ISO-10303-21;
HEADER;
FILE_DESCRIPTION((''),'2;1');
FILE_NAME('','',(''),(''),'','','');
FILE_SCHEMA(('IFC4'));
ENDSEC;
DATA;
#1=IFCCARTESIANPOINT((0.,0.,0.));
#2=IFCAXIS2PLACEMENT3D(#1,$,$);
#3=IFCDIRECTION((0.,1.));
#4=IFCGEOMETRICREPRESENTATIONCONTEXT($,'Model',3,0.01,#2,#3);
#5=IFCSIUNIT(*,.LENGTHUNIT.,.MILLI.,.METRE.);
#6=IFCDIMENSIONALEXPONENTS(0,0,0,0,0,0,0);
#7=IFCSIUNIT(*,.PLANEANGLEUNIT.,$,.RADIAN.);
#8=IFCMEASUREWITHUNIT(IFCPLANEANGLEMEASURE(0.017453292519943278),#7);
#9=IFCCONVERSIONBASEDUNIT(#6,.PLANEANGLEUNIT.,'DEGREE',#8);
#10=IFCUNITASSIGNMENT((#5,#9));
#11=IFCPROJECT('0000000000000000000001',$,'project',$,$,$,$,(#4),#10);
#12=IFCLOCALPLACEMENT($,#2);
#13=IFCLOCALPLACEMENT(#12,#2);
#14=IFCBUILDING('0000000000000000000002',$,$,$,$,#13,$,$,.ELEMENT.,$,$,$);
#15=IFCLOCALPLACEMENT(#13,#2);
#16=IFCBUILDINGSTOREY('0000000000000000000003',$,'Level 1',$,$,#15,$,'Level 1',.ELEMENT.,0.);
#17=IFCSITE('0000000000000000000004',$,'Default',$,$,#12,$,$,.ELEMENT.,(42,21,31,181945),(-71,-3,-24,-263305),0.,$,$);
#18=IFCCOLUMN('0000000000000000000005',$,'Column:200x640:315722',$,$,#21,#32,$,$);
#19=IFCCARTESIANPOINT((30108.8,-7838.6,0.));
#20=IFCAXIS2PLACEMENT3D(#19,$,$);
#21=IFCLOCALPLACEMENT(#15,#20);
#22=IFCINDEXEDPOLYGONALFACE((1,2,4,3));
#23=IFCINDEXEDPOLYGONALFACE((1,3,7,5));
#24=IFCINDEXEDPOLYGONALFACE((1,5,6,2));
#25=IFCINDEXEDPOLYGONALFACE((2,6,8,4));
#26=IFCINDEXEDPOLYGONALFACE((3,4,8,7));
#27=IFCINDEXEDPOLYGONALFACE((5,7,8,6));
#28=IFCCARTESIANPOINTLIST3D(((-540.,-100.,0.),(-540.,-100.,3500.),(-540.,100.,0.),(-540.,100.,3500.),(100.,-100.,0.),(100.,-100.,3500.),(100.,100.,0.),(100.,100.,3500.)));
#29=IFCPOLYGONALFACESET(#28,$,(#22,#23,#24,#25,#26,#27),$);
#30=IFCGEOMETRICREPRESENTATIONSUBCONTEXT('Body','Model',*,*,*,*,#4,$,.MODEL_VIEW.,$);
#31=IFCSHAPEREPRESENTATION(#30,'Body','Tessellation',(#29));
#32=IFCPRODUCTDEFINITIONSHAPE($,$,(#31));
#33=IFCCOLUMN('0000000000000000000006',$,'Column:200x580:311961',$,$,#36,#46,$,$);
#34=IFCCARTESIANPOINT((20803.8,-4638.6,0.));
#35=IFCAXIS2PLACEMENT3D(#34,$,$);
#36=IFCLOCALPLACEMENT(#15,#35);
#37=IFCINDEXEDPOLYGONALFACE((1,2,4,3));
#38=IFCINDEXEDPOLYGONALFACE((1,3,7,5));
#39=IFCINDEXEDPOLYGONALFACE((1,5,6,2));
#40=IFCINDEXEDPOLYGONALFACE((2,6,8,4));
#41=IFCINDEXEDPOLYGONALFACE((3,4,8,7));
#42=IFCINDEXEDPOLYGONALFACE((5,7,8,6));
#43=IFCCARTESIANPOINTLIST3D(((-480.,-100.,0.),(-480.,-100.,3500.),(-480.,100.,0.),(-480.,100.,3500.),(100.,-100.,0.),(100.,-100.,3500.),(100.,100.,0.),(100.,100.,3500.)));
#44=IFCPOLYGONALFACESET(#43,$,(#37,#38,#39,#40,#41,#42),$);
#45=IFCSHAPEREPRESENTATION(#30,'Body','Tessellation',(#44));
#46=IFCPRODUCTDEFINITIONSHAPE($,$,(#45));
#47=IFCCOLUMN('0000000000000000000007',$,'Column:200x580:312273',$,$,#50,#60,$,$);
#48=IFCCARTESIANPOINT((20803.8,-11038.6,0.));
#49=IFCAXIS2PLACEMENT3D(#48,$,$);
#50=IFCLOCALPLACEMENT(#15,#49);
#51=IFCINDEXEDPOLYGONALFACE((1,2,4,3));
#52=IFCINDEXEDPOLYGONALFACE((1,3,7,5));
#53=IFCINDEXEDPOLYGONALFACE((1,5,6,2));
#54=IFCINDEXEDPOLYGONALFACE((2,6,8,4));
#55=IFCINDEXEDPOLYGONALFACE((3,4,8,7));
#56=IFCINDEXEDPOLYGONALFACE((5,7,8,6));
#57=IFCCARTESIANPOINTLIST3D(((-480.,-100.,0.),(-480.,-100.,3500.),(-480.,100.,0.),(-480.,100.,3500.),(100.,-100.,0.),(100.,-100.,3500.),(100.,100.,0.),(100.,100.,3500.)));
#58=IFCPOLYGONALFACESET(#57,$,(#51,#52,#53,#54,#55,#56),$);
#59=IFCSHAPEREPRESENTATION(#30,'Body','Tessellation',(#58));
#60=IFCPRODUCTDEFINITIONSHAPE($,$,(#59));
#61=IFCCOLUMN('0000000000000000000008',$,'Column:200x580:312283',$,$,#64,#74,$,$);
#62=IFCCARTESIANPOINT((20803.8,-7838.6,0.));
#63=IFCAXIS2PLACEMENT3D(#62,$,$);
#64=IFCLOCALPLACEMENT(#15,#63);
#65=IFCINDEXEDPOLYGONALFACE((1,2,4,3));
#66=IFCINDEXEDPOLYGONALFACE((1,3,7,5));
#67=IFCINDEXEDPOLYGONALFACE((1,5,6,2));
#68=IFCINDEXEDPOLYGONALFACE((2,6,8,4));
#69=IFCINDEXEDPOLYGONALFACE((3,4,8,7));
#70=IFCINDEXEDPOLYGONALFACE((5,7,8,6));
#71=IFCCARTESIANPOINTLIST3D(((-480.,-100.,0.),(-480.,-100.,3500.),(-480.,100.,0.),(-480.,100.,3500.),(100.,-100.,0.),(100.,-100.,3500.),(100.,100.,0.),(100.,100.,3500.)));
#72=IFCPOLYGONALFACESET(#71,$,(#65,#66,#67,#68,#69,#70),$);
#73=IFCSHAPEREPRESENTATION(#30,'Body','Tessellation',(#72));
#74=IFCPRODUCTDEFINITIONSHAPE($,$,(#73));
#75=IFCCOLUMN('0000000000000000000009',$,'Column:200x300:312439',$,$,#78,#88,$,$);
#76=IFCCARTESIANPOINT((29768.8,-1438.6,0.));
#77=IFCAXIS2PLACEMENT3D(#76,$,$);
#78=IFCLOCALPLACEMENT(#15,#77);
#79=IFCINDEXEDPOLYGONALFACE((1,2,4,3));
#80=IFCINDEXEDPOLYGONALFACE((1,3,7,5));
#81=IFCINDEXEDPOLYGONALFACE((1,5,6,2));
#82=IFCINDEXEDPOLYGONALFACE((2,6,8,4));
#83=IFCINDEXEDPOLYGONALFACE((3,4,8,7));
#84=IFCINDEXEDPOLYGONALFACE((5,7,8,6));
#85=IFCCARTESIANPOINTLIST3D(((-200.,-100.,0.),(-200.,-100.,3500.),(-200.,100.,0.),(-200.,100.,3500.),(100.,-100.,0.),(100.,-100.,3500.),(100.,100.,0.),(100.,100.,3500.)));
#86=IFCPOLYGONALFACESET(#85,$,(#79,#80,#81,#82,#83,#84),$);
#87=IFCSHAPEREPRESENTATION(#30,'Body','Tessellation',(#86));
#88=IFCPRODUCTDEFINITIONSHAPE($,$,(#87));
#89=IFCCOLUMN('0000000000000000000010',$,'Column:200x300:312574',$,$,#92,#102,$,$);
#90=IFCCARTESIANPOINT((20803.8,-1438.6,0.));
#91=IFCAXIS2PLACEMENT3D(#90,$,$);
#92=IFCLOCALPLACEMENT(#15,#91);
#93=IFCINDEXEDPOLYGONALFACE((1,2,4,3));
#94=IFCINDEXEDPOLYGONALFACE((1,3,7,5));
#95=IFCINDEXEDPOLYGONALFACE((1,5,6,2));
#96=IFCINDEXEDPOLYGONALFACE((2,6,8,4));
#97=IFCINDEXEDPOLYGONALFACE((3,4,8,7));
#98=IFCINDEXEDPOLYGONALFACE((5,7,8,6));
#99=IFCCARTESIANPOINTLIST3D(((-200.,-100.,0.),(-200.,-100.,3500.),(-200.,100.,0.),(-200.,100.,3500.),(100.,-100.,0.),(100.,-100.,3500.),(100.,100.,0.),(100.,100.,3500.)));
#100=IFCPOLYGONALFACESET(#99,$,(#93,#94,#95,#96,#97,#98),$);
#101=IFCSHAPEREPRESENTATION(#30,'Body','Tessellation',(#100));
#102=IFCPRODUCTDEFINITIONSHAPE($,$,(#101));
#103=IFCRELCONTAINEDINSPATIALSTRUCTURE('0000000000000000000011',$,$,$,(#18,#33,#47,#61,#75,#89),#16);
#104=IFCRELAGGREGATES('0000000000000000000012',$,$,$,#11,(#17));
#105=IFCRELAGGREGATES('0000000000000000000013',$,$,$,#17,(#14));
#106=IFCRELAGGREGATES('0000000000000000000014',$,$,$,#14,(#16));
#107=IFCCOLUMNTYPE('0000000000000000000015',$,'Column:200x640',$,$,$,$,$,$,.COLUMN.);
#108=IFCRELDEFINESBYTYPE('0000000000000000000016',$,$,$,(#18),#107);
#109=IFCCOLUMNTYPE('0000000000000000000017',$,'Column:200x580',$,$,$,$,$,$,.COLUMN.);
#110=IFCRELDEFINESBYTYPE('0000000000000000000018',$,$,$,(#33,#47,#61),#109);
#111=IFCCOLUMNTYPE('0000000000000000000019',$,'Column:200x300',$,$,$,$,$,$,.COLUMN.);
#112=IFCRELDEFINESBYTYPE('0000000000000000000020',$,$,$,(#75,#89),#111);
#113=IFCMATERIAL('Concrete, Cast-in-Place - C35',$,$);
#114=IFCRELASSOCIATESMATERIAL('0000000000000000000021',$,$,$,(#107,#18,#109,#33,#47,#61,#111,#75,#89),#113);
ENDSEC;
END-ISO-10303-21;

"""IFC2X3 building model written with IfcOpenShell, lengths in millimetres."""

from ifc_helpers import new_model, entity, si_unit, converted_unit, direction, frame, origin, origin_2d_with_axis, place, context, subcontext, project, spatial, rectangle, extrude, source, transform, mapped, material, type_object, type_shapes, element, save


model = new_model("IFC2X3")

# Units and contexts
model_context = context("Model", 3, precision=0.01, world=origin(), true_north=direction((0.0, 1.0)))
body_context = subcontext(model_context, "Body", "Model", "MODEL_VIEW")
ifc_project = project(units=[si_unit("LENGTHUNIT", "METRE", prefix="MILLI"), converted_unit("PLANEANGLEUNIT", "DEGREE", entity("IfcPlaneAngleMeasure", 0.017453292519943278), si_unit("PLANEANGLEUNIT", "RADIAN"), dimensions=[0, 0, 0, 0, 0, 0, 0])], contexts=[model_context])

# Site, building, storey
site_placement = place(None, origin())
site = spatial("IfcSite", under=ifc_project, at=site_placement, Name="Default", CompositionType="ELEMENT", RefLatitude=(42, 21, 31, 181945), RefLongitude=(-71, -3, -24, -263305), RefElevation=0.0)
building_placement = place(site_placement, origin())
building = spatial("IfcBuilding", under=site, at=building_placement, CompositionType="ELEMENT")
storey_placement = place(building_placement, origin())
storey = spatial("IfcBuildingStorey", under=building, at=storey_placement, Name="Level 1", LongName="Level 1", CompositionType="ELEMENT", Elevation=0.0)

# Columns
ifc_material = material(Name="Concrete, Cast-in-Place - C35")
column_type_1 = type_object("IfcColumnType", Name="Column:200x640", PredefinedType="COLUMN", material=ifc_material)
shared_shape_1 = source(origin(), body_context, "Body", "SweptSolid", [
    extrude(rectangle(XDim=640.0, YDim=200.0, at=origin_2d_with_axis()), frame((-220.0, 0.0, 0.0), z_axis=(0.0, 0.0, 1.0), x_axis=(-1.0, 0.0, 0.0)), (0.0, 0.0, 1.0), 3500.0),
])
type_shapes(column_type_1, [shared_shape_1])
for number, where, name in (
    (1, (30108.8, -7838.6, 0.0), "Column:200x640:315722"),
):
    element("IfcColumn", number, at=place(storey_placement, frame(where)), inside=storey, type_object=column_type_1, material=ifc_material, Name=name, context=body_context, shape_type="MappedRepresentation", body=[
        mapped(shared_shape_1, transform((0.0, 0.0, 0.0), scale=1.0)),
    ])
column_type_2 = type_object("IfcColumnType", Name="Column:200x580", PredefinedType="COLUMN", material=ifc_material)
shared_shape_2 = source(origin(), body_context, "Body", "SweptSolid", [
    extrude(rectangle(XDim=580.0, YDim=200.0, at=origin_2d_with_axis()), frame((-190.0, 0.0, 0.0), z_axis=(0.0, 0.0, 1.0), x_axis=(-1.0, 0.0, 0.0)), (0.0, 0.0, 1.0), 3500.0),
])
type_shapes(column_type_2, [shared_shape_2])
for number, where, name in (
    (2, (20803.8, -4638.6, 0.0), "Column:200x580:311961"),
    (3, (20803.8, -11038.6, 0.0), "Column:200x580:312273"),
    (4, (20803.8, -7838.6, 0.0), "Column:200x580:312283"),
):
    element("IfcColumn", number, at=place(storey_placement, frame(where)), inside=storey, type_object=column_type_2, material=ifc_material, Name=name, context=body_context, shape_type="MappedRepresentation", body=[
        mapped(shared_shape_2, transform((0.0, 0.0, 0.0), scale=1.0)),
    ])
column_type_3 = type_object("IfcColumnType", Name="Column:200x300", PredefinedType="COLUMN", material=ifc_material)
shared_shape_3 = source(origin(), body_context, "Body", "SweptSolid", [
    extrude(rectangle(XDim=300.0, YDim=200.0, at=origin_2d_with_axis()), frame((-50.0, 0.0, 0.0), z_axis=(0.0, 0.0, 1.0), x_axis=(-1.0, 0.0, 0.0)), (0.0, 0.0, 1.0), 3500.0),
])
type_shapes(column_type_3, [shared_shape_3])
for number, where, name in (
    (5, (29768.8, -1438.6, 0.0), "Column:200x300:312439"),
    (6, (20803.8, -1438.6, 0.0), "Column:200x300:312574"),
):
    element("IfcColumn", number, at=place(storey_placement, frame(where)), inside=storey, type_object=column_type_3, material=ifc_material, Name=name, context=body_context, shape_type="MappedRepresentation", body=[
        mapped(shared_shape_3, transform((0.0, 0.0, 0.0), scale=1.0)),
    ])

save(model, "model.ifc")
